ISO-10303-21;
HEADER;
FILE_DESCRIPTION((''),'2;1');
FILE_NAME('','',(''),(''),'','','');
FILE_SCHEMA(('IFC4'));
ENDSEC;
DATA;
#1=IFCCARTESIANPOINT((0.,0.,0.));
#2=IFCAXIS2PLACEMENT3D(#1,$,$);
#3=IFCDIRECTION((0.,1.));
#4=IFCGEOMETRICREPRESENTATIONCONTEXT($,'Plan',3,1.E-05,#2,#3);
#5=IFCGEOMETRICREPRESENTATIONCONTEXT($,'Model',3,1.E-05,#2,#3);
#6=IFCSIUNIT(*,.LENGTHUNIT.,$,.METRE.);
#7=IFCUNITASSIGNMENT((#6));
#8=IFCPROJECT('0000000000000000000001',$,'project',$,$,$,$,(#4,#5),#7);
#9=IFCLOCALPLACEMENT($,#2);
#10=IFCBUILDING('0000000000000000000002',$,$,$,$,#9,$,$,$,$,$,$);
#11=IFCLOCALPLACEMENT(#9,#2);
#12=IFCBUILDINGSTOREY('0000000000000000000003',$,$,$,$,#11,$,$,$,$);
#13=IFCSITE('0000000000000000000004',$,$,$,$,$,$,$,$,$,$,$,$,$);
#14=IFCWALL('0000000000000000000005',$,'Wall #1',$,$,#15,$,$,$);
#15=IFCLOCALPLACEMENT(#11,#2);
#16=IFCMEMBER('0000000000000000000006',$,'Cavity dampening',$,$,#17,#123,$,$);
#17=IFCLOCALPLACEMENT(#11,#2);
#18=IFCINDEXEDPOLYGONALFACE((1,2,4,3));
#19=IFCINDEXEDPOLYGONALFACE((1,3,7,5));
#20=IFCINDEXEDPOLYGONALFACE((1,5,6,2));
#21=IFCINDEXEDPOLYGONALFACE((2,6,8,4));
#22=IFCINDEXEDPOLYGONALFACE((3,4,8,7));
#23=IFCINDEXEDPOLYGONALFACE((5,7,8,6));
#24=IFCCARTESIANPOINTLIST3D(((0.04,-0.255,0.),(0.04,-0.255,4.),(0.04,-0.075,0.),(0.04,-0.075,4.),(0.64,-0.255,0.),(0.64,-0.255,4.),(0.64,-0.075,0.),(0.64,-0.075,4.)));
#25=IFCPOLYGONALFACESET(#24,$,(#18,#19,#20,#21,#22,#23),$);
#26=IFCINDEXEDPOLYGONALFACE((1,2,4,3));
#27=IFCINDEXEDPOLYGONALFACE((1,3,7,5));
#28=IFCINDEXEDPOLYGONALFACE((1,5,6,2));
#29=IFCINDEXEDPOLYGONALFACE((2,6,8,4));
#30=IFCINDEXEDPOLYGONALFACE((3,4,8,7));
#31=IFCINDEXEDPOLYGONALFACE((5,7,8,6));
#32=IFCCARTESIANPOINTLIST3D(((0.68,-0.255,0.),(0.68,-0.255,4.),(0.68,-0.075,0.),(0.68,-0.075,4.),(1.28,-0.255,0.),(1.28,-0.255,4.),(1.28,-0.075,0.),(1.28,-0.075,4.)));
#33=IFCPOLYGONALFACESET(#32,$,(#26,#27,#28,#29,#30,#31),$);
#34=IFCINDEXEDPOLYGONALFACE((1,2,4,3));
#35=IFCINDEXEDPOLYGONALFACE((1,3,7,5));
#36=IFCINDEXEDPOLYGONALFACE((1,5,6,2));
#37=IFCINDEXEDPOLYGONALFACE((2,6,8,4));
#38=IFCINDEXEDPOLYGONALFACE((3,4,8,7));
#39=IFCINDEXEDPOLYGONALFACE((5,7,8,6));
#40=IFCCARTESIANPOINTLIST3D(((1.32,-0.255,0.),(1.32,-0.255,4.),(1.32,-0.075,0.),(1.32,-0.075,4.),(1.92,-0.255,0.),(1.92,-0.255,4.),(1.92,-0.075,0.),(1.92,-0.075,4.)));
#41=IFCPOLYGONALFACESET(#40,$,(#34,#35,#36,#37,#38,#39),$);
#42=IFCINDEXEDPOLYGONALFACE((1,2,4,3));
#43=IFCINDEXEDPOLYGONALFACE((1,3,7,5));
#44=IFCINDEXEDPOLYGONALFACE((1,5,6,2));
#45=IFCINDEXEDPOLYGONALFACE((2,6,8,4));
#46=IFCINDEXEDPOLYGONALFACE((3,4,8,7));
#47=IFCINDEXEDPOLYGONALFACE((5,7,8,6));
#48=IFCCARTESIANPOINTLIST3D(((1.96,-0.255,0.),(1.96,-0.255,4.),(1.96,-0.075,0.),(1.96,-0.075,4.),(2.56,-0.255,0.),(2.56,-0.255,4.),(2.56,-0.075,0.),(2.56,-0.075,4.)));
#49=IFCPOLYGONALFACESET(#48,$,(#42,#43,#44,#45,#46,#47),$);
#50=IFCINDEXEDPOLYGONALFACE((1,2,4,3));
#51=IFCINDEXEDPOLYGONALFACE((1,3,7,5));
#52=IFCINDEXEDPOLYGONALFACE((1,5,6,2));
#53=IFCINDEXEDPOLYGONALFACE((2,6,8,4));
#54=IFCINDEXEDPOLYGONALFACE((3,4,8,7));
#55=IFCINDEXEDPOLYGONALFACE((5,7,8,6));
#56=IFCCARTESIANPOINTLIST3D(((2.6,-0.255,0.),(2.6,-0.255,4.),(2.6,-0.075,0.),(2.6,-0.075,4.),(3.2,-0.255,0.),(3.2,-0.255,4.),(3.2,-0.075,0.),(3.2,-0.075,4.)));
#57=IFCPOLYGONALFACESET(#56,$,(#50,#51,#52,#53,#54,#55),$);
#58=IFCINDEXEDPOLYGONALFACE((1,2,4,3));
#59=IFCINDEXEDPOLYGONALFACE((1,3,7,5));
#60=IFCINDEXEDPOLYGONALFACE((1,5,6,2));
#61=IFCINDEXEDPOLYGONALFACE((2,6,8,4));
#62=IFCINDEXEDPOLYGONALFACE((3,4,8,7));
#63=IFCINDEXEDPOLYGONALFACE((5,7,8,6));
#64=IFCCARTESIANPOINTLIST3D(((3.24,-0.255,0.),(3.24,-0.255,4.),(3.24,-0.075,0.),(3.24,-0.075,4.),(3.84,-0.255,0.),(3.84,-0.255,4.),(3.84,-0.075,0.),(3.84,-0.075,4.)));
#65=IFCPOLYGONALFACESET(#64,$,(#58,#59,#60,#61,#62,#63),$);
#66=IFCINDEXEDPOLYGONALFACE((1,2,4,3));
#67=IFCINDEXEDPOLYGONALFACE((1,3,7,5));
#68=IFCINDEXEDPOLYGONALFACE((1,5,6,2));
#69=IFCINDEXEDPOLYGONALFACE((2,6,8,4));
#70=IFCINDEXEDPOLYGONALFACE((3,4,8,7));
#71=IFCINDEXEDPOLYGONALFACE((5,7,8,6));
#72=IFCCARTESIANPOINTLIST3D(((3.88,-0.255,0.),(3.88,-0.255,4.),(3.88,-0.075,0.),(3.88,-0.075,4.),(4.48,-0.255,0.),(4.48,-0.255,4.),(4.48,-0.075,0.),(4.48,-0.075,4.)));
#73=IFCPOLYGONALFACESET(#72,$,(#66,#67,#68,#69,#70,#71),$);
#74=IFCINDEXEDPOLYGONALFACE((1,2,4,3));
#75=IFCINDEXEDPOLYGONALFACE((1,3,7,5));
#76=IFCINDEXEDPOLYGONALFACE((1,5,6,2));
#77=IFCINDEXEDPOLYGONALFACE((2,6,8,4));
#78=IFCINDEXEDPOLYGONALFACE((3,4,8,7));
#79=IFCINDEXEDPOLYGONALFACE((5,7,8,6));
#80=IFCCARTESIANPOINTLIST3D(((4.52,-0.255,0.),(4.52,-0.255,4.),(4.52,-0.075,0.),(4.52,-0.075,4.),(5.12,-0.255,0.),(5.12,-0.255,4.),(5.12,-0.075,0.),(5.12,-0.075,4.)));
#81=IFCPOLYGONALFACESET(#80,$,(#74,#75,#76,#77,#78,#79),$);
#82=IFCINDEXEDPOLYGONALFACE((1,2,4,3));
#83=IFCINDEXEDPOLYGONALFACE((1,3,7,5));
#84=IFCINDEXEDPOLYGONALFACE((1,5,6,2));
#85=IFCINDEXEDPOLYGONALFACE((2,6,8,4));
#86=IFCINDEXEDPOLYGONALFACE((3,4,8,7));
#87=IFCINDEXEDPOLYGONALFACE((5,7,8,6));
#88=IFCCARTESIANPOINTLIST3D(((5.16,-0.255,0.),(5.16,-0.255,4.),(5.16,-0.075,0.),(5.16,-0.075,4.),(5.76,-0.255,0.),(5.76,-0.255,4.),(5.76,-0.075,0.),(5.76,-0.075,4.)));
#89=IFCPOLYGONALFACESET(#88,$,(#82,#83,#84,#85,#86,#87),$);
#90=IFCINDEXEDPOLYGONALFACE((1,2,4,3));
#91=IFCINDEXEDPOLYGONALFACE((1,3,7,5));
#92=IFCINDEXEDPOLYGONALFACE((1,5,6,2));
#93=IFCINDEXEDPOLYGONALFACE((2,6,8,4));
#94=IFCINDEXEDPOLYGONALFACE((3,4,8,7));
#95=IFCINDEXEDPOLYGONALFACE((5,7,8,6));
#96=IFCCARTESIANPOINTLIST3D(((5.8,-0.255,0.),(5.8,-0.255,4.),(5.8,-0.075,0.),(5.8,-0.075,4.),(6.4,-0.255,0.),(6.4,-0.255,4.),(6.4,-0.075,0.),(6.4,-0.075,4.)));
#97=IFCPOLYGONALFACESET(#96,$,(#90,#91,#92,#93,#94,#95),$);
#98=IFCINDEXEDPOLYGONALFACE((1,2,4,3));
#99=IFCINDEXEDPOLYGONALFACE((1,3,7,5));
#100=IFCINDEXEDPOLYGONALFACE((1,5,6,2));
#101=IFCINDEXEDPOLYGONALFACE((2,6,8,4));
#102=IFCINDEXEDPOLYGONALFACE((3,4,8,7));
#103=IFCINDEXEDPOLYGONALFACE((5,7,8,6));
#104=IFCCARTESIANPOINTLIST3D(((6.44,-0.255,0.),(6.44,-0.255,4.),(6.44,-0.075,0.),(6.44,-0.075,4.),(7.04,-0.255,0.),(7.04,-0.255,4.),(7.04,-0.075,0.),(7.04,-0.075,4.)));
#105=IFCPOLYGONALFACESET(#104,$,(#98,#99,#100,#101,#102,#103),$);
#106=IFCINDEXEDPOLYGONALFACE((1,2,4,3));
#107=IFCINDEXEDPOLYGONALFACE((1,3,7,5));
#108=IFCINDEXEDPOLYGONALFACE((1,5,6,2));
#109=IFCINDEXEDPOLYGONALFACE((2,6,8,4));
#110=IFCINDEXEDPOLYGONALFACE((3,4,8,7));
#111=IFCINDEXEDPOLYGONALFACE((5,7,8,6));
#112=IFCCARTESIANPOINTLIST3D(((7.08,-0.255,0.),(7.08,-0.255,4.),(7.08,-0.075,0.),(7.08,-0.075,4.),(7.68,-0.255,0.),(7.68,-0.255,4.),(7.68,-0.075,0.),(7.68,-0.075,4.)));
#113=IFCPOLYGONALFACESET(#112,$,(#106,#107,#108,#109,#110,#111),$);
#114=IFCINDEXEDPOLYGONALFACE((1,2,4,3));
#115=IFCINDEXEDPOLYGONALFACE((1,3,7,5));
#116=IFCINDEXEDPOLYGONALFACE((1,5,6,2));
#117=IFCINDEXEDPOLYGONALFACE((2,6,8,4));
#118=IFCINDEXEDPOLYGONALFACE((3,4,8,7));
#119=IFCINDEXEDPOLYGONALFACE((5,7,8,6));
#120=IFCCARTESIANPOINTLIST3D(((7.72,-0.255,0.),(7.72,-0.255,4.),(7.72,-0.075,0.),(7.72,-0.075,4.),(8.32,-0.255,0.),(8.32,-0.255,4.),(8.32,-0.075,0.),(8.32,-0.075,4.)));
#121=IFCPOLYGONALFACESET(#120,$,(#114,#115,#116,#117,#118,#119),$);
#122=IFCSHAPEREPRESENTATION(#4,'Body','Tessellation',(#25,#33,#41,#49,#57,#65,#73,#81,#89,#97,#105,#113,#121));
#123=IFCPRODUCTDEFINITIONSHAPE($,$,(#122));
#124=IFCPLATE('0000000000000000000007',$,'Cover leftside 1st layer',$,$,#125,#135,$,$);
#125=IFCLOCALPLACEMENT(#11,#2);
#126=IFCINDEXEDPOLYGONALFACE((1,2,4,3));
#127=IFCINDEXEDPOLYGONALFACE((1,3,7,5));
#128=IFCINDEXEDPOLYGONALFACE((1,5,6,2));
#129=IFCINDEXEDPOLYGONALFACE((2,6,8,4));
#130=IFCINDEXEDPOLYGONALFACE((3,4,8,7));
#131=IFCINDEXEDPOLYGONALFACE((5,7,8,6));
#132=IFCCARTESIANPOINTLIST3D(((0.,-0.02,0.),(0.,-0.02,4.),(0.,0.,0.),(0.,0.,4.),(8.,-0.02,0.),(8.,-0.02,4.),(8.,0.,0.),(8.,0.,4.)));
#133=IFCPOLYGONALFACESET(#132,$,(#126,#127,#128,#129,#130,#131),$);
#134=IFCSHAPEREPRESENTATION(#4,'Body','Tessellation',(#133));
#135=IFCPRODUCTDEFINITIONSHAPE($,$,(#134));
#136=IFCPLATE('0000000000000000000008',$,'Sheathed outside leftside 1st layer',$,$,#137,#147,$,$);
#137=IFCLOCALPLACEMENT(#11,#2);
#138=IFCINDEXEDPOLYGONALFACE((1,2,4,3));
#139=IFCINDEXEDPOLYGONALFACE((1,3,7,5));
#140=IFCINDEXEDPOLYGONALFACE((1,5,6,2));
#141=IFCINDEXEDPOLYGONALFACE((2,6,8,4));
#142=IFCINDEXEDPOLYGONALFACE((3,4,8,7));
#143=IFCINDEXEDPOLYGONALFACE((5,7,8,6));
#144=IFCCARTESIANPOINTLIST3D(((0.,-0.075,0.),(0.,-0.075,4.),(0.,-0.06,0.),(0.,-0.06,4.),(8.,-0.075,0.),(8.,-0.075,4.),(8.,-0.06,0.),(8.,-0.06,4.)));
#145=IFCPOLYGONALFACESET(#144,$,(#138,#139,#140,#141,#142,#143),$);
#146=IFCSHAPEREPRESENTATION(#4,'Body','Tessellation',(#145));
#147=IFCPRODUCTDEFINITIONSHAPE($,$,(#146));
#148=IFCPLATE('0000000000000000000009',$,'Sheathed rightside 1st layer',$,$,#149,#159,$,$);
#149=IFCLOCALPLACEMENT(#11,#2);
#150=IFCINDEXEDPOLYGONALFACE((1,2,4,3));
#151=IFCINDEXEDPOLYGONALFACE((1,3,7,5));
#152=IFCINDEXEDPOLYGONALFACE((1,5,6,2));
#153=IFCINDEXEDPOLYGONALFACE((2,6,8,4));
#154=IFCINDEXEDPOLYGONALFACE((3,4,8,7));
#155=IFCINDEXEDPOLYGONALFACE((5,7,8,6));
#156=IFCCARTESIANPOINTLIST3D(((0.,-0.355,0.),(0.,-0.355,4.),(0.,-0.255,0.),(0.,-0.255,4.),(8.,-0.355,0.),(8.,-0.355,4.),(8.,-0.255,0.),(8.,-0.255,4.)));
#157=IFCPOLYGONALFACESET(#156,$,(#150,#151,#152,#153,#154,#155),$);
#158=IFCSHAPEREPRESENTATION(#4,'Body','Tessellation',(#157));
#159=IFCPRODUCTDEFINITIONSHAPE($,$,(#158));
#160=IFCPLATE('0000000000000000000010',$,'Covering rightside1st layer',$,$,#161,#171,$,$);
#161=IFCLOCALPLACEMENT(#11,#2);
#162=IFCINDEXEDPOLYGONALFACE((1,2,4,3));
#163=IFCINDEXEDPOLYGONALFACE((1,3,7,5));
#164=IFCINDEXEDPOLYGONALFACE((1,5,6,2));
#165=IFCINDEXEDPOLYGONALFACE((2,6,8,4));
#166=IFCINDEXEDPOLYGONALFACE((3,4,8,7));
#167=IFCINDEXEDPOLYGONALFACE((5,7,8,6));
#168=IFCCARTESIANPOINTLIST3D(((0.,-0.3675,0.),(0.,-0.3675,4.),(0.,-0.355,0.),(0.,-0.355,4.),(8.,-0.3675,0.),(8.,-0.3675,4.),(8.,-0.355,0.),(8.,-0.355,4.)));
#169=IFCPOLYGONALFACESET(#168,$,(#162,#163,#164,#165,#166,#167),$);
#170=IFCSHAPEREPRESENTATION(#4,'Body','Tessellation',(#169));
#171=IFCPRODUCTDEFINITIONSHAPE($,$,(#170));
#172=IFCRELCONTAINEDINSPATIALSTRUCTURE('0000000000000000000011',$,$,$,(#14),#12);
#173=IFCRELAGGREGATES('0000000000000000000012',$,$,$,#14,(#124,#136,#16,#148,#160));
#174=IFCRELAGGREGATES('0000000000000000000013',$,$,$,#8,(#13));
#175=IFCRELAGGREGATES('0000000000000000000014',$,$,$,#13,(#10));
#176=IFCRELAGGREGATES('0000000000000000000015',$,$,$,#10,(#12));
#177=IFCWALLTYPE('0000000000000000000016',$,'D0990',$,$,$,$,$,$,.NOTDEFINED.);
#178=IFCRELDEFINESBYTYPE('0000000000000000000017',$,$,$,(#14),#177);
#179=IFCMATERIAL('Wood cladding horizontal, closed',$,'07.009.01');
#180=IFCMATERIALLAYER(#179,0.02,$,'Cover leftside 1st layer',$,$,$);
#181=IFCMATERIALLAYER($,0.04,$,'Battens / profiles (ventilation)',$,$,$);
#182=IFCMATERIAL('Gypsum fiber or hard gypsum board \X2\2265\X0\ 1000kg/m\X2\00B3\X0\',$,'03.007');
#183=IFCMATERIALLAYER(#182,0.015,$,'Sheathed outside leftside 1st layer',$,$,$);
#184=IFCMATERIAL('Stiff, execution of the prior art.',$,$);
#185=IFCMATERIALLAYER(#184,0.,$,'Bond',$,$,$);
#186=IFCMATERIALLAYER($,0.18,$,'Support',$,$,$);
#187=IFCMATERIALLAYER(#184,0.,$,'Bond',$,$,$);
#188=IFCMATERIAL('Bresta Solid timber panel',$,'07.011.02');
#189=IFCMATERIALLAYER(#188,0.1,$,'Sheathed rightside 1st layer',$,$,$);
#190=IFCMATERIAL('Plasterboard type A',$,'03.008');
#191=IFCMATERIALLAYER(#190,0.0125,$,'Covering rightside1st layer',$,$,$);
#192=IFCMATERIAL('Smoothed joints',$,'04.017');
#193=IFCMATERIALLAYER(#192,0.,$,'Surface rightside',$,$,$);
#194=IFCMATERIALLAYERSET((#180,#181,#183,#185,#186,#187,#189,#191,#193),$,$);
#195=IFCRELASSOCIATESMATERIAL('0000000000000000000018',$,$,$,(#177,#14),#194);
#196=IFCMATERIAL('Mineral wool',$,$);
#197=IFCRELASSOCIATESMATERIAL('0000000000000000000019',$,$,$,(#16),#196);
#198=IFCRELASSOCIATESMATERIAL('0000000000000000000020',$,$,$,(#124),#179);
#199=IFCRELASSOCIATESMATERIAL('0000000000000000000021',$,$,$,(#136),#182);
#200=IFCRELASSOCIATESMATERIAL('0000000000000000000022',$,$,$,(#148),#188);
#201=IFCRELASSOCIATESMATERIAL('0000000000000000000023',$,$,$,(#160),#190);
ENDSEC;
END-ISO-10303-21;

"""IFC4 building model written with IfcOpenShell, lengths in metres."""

from ifc_helpers import new_model, si_unit, direction, frame, frame_2d, origin, origin_with_axes, place, context, project, spatial, rectangle, extrude, material, layer, layer_set, type_object, element, aggregate, save


model = new_model("IFC4")

# Units and contexts
plan_context = context("Plan", 3, precision=1e-05, world=origin(), true_north=direction((0.0, 1.0)))
model_context = context("Model", 3, precision=1e-05, world=origin(), true_north=direction((0.0, 1.0)))
ifc_project = project(units=[si_unit("LENGTHUNIT", "METRE")], contexts=[plan_context, model_context])

# Site, building, storey
site = spatial("IfcSite", under=ifc_project)
building_placement = place(None, origin())
building = spatial("IfcBuilding", under=site, at=building_placement)
storey_placement = place(building_placement, origin())
storey = spatial("IfcBuildingStorey", under=building, at=storey_placement)

# Wall, member, plates
ifc_material_1 = material(Name="Wood cladding horizontal, closed", Category="07.009.01")
ifc_layer_1 = layer(ifc_material_1, 0.02, Name="Cover leftside 1st layer")
ifc_layer_2 = layer(None, 0.04, Name="Battens / profiles (ventilation)")
ifc_material_2 = material(Name="Gypsum fiber or hard gypsum board ≥ 1000kg/m³", Category="03.007")
ifc_layer_3 = layer(ifc_material_2, 0.015, Name="Sheathed outside leftside 1st layer")
ifc_material_3 = material(Name="Stiff, execution of the prior art.")
ifc_layer_4 = layer(ifc_material_3, 0.0, Name="Bond")
ifc_layer_5 = layer(None, 0.18, Name="Support")
ifc_layer_6 = layer(ifc_material_3, 0.0, Name="Bond")
ifc_material_4 = material(Name="Bresta Solid timber panel", Category="07.011.02")
ifc_layer_7 = layer(ifc_material_4, 0.1, Name="Sheathed rightside 1st layer")
ifc_material_5 = material(Name="Plasterboard type A", Category="03.008")
ifc_layer_8 = layer(ifc_material_5, 0.0125, Name="Covering rightside1st layer")
ifc_material_6 = material(Name="Smoothed joints", Category="04.017")
ifc_layer_9 = layer(ifc_material_6, 0.0, Name="Surface rightside")
ifc_layer_set = layer_set([ifc_layer_1, ifc_layer_2, ifc_layer_3, ifc_layer_4, ifc_layer_5, ifc_layer_6, ifc_layer_7, ifc_layer_8, ifc_layer_9])
wall_type = type_object("IfcWallType", Name="D0990", PredefinedType="NOTDEFINED", material=ifc_layer_set)
wall_placement = place(None, frame((0.0, 0.0, 0.0), z_axis=(0.0, -1.0, 0.0), x_axis=(1.0, 0.0, 0.0)))
wall = element("IfcWall", 1, at=wall_placement, inside=storey, type_object=wall_type, material=ifc_layer_set, Name="Wall #1")
ifc_material_7 = material(Name="Mineral wool")
member_1_placement = place(wall_placement, origin())
member_1 = element("IfcMember", 2, at=member_1_placement, material=ifc_material_7, Name="Cavity dampening", context=plan_context, shape_type="SweptSolid", body=[
    extrude(rectangle(XDim=0.6, YDim=0.18, at=frame_2d((0.3, 0.09), x_axis=(1.0, 0.0))), frame((0.04, 4.0, 0.075), z_axis=(0.0, -1.0, 0.0), x_axis=(1.0, 0.0, 0.0)), (0.0, 0.0, 1.0), 4.0),
    extrude(rectangle(XDim=0.6, YDim=0.18, at=frame_2d((0.3, 0.09), x_axis=(1.0, 0.0))), frame((0.68, 4.0, 0.075), z_axis=(0.0, -1.0, 0.0), x_axis=(1.0, 0.0, 0.0)), (0.0, 0.0, 1.0), 4.0),
    extrude(rectangle(XDim=0.6, YDim=0.18, at=frame_2d((0.3, 0.09), x_axis=(1.0, 0.0))), frame((1.32, 4.0, 0.075), z_axis=(0.0, -1.0, 0.0), x_axis=(1.0, 0.0, 0.0)), (0.0, 0.0, 1.0), 4.0),
    extrude(rectangle(XDim=0.6, YDim=0.18, at=frame_2d((0.3, 0.09), x_axis=(1.0, 0.0))), frame((1.96, 4.0, 0.075), z_axis=(0.0, -1.0, 0.0), x_axis=(1.0, 0.0, 0.0)), (0.0, 0.0, 1.0), 4.0),
    extrude(rectangle(XDim=0.6, YDim=0.18, at=frame_2d((0.3, 0.09), x_axis=(1.0, 0.0))), frame((2.6, 4.0, 0.075), z_axis=(0.0, -1.0, 0.0), x_axis=(1.0, 0.0, 0.0)), (0.0, 0.0, 1.0), 4.0),
    extrude(rectangle(XDim=0.6, YDim=0.18, at=frame_2d((0.3, 0.09), x_axis=(1.0, 0.0))), frame((3.24, 4.0, 0.075), z_axis=(0.0, -1.0, 0.0), x_axis=(1.0, 0.0, 0.0)), (0.0, 0.0, 1.0), 4.0),
    extrude(rectangle(XDim=0.6, YDim=0.18, at=frame_2d((0.3, 0.09), x_axis=(1.0, 0.0))), frame((3.88, 4.0, 0.075), z_axis=(0.0, -1.0, 0.0), x_axis=(1.0, 0.0, 0.0)), (0.0, 0.0, 1.0), 4.0),
    extrude(rectangle(XDim=0.6, YDim=0.18, at=frame_2d((0.3, 0.09), x_axis=(1.0, 0.0))), frame((4.52, 4.0, 0.075), z_axis=(0.0, -1.0, 0.0), x_axis=(1.0, 0.0, 0.0)), (0.0, 0.0, 1.0), 4.0),
    extrude(rectangle(XDim=0.6, YDim=0.18, at=frame_2d((0.3, 0.09), x_axis=(1.0, 0.0))), frame((5.16, 4.0, 0.075), z_axis=(0.0, -1.0, 0.0), x_axis=(1.0, 0.0, 0.0)), (0.0, 0.0, 1.0), 4.0),
    extrude(rectangle(XDim=0.6, YDim=0.18, at=frame_2d((0.3, 0.09), x_axis=(1.0, 0.0))), frame((5.8, 4.0, 0.075), z_axis=(0.0, -1.0, 0.0), x_axis=(1.0, 0.0, 0.0)), (0.0, 0.0, 1.0), 4.0),
    extrude(rectangle(XDim=0.6, YDim=0.18, at=frame_2d((0.3, 0.09), x_axis=(1.0, 0.0))), frame((6.44, 4.0, 0.075), z_axis=(0.0, -1.0, 0.0), x_axis=(1.0, 0.0, 0.0)), (0.0, 0.0, 1.0), 4.0),
    extrude(rectangle(XDim=0.6, YDim=0.18, at=frame_2d((0.3, 0.09), x_axis=(1.0, 0.0))), frame((7.08, 4.0, 0.075), z_axis=(0.0, -1.0, 0.0), x_axis=(1.0, 0.0, 0.0)), (0.0, 0.0, 1.0), 4.0),
    extrude(rectangle(XDim=0.6, YDim=0.18, at=frame_2d((0.3, 0.09), x_axis=(1.0, 0.0))), frame((7.72, 4.0, 0.075), z_axis=(0.0, -1.0, 0.0), x_axis=(1.0, 0.0, 0.0)), (0.0, 0.0, 1.0), 4.0),
])
plate_1_placement = place(wall_placement, origin())
plate_1 = element("IfcPlate", 3, at=plate_1_placement, material=ifc_material_1, Name="Cover leftside 1st layer", context=plan_context, shape_type="SweptSolid", body=[
    extrude(rectangle(XDim=8.0, YDim=4.0, at=frame_2d((4.0, 2.0), x_axis=(1.0, 0.0))), origin_with_axes(), (0.0, 0.0, 1.0), 0.02),
])
plate_2_placement = place(wall_placement, origin())
plate_2 = element("IfcPlate", 4, at=plate_2_placement, material=ifc_material_2, Name="Sheathed outside leftside 1st layer", context=plan_context, shape_type="SweptSolid", body=[
    extrude(rectangle(XDim=8.0, YDim=4.0, at=frame_2d((4.0, 2.0), x_axis=(1.0, 0.0))), frame((0.0, 0.0, 0.06), z_axis=(0.0, 0.0, 1.0), x_axis=(1.0, 0.0, 0.0)), (0.0, 0.0, 1.0), 0.015),
])
plate_3_placement = place(wall_placement, origin())
plate_3 = element("IfcPlate", 5, at=plate_3_placement, material=ifc_material_4, Name="Sheathed rightside 1st layer", context=plan_context, shape_type="SweptSolid", body=[
    extrude(rectangle(XDim=8.0, YDim=4.0, at=frame_2d((4.0, 2.0), x_axis=(1.0, 0.0))), frame((0.0, 0.0, 0.255), z_axis=(0.0, 0.0, 1.0), x_axis=(1.0, 0.0, 0.0)), (0.0, 0.0, 1.0), 0.1),
])
plate_4_placement = place(wall_placement, origin())
plate_4 = element("IfcPlate", 6, at=plate_4_placement, material=ifc_material_5, Name="Covering rightside1st layer", context=plan_context, shape_type="SweptSolid", body=[
    extrude(rectangle(XDim=8.0, YDim=4.0, at=frame_2d((4.0, 2.0), x_axis=(1.0, 0.0))), frame((0.0, 0.0, 0.355), z_axis=(0.0, 0.0, 1.0), x_axis=(1.0, 0.0, 0.0)), (0.0, 0.0, 1.0), 0.0125),
])
aggregate(wall, [plate_1, plate_2, member_1, plate_3, plate_4])

save(model, "model.ifc")
